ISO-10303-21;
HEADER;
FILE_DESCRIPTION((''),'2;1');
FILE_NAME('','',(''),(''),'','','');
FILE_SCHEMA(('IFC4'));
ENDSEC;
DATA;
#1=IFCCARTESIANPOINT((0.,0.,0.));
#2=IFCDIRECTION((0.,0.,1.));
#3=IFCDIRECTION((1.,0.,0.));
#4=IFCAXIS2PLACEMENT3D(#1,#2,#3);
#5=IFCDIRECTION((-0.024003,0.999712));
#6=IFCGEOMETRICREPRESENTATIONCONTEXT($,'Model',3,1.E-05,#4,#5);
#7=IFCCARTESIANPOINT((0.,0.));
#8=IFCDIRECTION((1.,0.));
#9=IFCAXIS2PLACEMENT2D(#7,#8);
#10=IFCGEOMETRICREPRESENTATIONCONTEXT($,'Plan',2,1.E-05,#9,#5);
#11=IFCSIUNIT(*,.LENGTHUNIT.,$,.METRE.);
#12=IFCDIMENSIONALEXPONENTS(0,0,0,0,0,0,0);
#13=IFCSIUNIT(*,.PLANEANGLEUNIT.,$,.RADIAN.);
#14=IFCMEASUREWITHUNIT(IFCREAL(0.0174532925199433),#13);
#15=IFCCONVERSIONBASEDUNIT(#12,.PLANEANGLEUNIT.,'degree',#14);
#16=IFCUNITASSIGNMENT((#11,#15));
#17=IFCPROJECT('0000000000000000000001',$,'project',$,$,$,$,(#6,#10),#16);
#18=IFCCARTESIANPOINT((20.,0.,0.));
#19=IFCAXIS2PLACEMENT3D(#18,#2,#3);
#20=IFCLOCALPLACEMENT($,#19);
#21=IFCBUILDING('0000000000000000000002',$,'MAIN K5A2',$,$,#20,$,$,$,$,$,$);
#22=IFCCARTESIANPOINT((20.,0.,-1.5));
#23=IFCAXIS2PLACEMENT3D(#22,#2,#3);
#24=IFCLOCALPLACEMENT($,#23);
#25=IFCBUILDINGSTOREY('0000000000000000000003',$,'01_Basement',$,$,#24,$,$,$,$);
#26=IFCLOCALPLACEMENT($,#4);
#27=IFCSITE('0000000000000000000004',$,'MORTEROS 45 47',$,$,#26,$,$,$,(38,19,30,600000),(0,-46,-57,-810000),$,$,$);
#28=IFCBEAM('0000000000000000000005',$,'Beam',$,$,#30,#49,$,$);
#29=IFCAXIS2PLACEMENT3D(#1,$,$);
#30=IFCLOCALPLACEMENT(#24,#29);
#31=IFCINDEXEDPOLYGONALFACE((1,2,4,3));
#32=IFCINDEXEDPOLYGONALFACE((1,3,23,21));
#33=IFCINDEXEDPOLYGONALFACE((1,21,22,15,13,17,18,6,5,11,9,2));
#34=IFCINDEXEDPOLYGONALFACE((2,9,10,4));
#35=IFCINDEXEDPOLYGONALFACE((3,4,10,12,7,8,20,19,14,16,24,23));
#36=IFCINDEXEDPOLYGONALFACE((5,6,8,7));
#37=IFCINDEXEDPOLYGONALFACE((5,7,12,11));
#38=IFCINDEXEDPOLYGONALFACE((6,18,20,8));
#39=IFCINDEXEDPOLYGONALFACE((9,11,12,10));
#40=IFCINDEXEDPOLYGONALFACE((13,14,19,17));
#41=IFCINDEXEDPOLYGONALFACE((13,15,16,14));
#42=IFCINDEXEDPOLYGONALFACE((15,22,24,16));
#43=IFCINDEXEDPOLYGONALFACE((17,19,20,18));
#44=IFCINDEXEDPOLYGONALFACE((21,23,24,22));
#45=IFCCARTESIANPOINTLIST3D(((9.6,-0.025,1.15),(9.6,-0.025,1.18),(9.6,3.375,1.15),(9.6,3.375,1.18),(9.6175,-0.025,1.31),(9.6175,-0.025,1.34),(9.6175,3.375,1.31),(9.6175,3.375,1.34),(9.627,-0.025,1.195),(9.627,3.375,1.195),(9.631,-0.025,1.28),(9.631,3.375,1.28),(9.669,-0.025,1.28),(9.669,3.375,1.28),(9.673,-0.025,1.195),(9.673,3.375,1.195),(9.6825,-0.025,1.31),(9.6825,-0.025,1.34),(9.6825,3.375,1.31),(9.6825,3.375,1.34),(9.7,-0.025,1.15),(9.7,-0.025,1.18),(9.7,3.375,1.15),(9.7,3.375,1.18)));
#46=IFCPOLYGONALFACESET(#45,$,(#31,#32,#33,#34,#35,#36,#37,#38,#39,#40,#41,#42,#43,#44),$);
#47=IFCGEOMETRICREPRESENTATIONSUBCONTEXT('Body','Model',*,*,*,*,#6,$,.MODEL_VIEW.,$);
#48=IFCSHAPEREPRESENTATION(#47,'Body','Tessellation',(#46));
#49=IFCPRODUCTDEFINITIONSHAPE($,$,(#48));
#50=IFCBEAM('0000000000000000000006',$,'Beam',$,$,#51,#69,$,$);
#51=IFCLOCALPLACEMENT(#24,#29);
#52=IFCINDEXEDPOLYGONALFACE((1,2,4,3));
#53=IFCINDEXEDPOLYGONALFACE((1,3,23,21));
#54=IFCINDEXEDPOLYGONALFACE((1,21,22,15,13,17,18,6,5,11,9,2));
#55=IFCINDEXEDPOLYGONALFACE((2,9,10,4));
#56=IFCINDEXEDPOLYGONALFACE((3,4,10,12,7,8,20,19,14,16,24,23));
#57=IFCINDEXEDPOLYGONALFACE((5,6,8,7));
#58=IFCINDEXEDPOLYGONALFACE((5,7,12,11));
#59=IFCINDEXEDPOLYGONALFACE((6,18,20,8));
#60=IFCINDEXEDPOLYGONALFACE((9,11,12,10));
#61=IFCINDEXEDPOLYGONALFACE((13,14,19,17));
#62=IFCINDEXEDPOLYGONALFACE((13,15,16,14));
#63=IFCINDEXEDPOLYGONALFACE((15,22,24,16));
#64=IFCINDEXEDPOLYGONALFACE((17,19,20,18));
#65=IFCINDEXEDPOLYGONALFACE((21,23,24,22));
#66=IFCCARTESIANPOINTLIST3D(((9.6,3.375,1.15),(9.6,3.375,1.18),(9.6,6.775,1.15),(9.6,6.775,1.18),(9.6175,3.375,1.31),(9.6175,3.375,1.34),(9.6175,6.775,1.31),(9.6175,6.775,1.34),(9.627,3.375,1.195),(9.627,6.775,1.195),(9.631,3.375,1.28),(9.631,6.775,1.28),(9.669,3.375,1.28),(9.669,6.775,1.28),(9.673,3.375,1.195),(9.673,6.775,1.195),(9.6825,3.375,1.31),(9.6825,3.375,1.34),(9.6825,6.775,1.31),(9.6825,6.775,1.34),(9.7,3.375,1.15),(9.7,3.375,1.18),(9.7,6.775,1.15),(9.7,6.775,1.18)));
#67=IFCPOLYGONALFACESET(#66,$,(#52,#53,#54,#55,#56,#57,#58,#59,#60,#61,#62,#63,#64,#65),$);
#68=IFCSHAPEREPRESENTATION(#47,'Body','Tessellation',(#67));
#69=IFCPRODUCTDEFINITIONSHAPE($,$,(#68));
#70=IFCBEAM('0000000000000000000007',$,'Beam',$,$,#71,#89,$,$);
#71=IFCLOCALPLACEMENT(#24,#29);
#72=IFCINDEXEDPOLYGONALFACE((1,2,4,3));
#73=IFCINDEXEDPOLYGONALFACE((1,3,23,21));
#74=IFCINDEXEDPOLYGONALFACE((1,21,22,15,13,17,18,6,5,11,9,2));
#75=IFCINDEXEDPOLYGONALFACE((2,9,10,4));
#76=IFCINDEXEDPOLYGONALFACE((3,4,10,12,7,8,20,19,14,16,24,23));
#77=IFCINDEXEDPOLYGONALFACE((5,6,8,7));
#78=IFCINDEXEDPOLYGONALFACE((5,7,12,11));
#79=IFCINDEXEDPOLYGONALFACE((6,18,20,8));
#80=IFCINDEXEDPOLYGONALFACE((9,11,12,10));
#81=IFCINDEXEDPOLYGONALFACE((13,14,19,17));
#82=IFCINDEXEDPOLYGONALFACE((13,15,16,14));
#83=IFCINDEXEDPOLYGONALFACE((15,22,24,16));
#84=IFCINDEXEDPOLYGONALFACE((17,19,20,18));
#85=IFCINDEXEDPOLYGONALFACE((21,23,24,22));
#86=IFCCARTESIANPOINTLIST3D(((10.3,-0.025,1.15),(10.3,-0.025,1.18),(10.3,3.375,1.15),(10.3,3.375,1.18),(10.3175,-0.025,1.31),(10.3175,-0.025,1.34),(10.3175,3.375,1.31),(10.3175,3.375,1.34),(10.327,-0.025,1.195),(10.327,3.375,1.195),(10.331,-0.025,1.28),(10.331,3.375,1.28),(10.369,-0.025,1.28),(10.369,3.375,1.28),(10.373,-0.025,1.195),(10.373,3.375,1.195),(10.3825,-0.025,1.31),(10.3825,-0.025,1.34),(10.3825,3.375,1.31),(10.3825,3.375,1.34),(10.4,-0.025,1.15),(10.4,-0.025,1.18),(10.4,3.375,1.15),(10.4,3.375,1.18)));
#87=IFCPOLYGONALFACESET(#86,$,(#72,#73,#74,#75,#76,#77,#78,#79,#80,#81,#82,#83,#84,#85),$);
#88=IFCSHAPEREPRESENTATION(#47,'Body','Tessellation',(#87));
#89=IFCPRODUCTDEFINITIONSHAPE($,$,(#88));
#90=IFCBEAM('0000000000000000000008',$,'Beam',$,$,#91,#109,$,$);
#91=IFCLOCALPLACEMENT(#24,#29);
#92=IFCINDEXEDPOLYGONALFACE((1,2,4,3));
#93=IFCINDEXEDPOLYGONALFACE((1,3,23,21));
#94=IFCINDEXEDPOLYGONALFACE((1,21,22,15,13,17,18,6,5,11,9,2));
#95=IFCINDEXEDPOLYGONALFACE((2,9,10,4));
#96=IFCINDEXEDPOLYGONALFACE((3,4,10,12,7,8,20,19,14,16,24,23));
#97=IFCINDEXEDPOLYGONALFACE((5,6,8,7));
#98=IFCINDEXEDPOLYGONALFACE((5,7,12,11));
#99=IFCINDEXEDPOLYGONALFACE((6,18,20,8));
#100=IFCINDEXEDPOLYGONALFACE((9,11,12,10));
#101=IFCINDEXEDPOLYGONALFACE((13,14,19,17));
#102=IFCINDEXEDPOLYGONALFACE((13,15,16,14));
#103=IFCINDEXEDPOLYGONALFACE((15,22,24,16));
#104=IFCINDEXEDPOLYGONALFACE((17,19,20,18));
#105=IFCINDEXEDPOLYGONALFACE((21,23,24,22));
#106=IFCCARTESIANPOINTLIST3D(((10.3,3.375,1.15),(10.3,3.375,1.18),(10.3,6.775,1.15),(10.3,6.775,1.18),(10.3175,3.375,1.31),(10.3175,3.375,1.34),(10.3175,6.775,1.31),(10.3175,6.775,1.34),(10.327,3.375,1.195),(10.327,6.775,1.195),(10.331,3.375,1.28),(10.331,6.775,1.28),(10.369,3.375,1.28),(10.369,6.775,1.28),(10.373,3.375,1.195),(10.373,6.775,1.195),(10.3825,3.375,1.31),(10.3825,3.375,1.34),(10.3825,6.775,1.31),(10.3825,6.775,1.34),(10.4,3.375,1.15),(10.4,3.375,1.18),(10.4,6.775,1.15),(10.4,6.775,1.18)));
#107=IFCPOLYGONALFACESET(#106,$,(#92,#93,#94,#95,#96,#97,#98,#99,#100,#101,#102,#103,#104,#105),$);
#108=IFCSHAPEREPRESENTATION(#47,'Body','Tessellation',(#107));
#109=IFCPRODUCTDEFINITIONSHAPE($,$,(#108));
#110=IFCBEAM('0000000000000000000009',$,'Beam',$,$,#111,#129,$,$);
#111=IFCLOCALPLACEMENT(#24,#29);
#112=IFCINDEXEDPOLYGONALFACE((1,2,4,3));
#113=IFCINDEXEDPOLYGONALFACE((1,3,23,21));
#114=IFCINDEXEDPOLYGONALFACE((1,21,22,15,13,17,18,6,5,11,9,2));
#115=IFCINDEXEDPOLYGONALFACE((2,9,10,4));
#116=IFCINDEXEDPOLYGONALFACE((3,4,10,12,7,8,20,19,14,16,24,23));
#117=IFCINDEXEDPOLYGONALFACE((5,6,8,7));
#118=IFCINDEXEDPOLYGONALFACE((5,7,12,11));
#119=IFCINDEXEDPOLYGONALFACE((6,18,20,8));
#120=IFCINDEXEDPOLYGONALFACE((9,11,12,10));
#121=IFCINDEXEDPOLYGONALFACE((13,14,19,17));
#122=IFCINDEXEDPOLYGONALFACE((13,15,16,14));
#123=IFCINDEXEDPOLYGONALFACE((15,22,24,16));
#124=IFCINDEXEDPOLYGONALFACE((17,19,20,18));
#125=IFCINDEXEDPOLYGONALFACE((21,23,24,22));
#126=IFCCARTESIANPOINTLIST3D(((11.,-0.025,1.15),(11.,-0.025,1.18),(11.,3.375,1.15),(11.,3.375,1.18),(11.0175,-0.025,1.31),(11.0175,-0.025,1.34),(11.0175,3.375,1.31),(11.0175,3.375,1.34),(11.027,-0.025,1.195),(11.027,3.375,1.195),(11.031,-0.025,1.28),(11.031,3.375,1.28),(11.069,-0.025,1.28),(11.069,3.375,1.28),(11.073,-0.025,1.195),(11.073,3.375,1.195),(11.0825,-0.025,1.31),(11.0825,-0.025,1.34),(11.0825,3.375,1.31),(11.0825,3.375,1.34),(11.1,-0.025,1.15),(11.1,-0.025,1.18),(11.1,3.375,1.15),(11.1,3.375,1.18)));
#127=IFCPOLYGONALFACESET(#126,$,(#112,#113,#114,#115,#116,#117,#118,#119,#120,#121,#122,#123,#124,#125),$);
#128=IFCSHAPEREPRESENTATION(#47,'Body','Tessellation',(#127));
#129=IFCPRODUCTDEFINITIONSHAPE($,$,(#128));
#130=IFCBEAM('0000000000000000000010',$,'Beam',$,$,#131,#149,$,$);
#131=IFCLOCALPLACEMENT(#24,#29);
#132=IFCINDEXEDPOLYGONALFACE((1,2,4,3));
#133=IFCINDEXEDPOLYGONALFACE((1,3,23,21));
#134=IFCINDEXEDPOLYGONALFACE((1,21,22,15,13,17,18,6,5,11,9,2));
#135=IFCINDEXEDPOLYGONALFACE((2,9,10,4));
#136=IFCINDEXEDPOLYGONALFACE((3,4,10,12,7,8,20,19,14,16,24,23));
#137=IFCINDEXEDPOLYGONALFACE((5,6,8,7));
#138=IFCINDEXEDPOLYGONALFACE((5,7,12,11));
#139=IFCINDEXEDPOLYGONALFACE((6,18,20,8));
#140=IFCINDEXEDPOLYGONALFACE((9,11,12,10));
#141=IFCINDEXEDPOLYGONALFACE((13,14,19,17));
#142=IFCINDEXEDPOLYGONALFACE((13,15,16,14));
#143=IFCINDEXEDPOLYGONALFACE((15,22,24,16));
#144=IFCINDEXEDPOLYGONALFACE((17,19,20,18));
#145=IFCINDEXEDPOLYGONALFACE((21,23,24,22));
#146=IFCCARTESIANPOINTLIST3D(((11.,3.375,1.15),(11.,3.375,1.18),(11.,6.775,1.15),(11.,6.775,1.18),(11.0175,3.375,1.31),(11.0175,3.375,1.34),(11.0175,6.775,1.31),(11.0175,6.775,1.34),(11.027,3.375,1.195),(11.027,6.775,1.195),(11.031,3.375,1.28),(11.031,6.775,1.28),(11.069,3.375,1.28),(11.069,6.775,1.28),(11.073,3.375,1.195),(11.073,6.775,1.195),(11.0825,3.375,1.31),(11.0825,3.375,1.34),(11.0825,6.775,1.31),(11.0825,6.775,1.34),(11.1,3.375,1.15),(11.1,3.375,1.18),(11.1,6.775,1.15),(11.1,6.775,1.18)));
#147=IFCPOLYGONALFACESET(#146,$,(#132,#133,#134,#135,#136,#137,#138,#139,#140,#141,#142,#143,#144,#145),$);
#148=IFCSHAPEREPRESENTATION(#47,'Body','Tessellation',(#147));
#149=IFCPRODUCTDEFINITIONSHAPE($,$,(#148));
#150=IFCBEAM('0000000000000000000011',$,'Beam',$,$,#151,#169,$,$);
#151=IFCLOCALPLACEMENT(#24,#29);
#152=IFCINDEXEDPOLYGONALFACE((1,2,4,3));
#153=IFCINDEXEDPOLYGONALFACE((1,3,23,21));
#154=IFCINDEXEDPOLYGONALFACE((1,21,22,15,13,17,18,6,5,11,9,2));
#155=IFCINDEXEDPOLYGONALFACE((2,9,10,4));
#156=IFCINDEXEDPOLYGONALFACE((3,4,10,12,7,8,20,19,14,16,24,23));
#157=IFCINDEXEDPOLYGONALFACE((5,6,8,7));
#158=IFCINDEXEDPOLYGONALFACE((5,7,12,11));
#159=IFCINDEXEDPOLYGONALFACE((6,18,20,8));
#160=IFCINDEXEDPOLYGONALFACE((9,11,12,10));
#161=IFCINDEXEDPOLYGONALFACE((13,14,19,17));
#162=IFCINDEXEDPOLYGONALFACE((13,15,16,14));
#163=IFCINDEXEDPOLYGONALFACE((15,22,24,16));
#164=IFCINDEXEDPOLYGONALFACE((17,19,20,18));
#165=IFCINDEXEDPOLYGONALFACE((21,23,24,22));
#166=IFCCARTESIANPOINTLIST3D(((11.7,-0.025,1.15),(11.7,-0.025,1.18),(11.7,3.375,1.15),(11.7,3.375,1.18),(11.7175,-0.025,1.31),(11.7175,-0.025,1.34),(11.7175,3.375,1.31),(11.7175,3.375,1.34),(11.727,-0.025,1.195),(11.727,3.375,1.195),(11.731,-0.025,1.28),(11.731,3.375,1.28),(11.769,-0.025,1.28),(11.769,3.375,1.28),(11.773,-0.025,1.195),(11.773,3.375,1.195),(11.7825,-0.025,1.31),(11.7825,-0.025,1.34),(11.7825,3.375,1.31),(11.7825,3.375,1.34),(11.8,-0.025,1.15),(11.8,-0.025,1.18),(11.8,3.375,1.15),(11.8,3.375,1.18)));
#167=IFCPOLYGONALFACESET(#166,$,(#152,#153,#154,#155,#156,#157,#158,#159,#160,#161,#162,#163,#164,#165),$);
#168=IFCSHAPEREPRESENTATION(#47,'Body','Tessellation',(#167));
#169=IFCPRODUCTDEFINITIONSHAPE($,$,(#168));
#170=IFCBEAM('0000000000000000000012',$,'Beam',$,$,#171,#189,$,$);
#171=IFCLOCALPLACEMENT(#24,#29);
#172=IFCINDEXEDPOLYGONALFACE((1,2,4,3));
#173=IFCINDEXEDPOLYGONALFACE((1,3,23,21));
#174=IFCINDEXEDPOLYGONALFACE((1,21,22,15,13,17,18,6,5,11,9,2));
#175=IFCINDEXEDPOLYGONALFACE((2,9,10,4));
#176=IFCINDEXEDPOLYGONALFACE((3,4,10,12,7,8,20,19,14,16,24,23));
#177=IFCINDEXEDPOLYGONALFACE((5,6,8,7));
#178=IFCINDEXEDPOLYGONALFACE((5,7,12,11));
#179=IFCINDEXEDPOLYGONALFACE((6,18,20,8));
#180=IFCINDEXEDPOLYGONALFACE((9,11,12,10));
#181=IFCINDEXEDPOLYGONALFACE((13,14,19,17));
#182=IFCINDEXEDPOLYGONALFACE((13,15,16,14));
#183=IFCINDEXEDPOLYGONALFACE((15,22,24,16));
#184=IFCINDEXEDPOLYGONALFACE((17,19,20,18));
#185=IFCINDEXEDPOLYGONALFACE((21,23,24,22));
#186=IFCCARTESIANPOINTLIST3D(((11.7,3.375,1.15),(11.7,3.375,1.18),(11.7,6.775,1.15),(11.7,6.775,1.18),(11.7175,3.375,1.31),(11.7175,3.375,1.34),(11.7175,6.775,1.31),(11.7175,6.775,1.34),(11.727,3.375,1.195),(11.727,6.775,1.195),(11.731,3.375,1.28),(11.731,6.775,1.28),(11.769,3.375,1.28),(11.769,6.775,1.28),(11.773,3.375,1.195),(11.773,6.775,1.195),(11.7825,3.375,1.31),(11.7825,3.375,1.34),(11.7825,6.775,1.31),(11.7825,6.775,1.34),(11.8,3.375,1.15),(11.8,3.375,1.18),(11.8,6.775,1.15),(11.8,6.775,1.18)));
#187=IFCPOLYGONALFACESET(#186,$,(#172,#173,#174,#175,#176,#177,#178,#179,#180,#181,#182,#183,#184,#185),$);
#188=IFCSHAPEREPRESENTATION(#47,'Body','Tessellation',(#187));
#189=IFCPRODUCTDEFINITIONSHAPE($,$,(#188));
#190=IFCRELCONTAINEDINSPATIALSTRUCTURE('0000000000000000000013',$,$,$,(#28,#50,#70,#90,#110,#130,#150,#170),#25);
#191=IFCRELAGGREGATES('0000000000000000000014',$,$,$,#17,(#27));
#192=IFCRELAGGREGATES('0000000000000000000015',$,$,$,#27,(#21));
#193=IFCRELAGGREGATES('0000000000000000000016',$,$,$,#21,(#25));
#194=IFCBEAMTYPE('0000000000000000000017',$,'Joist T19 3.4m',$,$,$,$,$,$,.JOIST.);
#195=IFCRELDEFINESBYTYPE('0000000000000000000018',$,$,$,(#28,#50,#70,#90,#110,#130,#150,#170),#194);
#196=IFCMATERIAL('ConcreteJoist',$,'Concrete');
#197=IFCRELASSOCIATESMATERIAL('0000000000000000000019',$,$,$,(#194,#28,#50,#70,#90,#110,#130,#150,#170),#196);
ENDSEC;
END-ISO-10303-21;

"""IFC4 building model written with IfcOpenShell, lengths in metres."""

from ifc_helpers import new_model, entity, si_unit, converted_unit, direction, frame, origin_with_axes, origin_2d_with_axis, place, context, subcontext, project, spatial, indexed_curve, outline, extrude, material, material_profile, profile_set, profile_usage, type_object, element, save


model = new_model("IFC4")

# Units and contexts
model_context = context("Model", 3, precision=1e-05, world=origin_with_axes(), true_north=direction((-0.024003, 0.999712)))
plan_context = context("Plan", 2, precision=1e-05, world=origin_2d_with_axis(), true_north=direction((-0.024003, 0.999712)))
body_context = subcontext(model_context, "Body", "Model", "MODEL_VIEW")
ifc_project = project(units=[si_unit("LENGTHUNIT", "METRE"), converted_unit("PLANEANGLEUNIT", "degree", entity("IfcReal", 0.0174532925199433), si_unit("PLANEANGLEUNIT", "RADIAN"), dimensions=[0, 0, 0, 0, 0, 0, 0])], contexts=[model_context, plan_context])

# Site, building, storey
site_placement = place(None, origin_with_axes())
site = spatial("IfcSite", under=ifc_project, at=site_placement, Name="MORTEROS 45 47", RefLatitude=(38, 19, 30, 600000), RefLongitude=(0, -46, -57, -810000))
building_placement = place(None, frame((20.0, 0.0, 0.0), z_axis=(0.0, 0.0, 1.0), x_axis=(1.0, 0.0, 0.0)))
building = spatial("IfcBuilding", under=site, at=building_placement, Name="MAIN K5A2")
storey_placement = place(None, frame((20.0, 0.0, -1.5), z_axis=(0.0, 0.0, 1.0), x_axis=(1.0, 0.0, 0.0)))
storey = spatial("IfcBuildingStorey", under=building, at=storey_placement, Name="01_Basement")

# Beams
ifc_material = material(Name="ConcreteJoist", Category="Concrete")
ifc_material_profile = material_profile(ifc_material, outline(indexed_curve([(0.019, 0.13), (0.023, 0.045), (0.05, 0.03), (0.05, 0.0), (-0.05, 0.0), (-0.05, 0.03), (-0.023, 0.045), (-0.019, 0.13), (-0.0325, 0.16), (-0.0325, 0.19), (0.0325, 0.19), (0.0325, 0.16), (0.019, 0.13)])))
ifc_profile_set = profile_set([ifc_material_profile], Name="JoistMaterialProfileSet")
beam_type = type_object("IfcBeamType", Name="Joist T19 3.4m", PredefinedType="JOIST", material=ifc_profile_set)
ifc_profile_usage_1 = profile_usage(ifc_profile_set, cardinal=5)
beam_1_placement = place(None, frame((29.65, -0.025, -0.35), z_axis=(0.0, 1.0, 0.0), x_axis=(-1.0, 0.0, 0.0)))
element("IfcBeam", 1, at=beam_1_placement, inside=storey, type_object=beam_type, material=ifc_profile_usage_1, Name="Beam", context=body_context, shape_type="SweptSolid", body=[
    extrude(outline(indexed_curve([(0.019, 0.13), (0.023, 0.045), (0.05, 0.03), (0.05, 0.0), (-0.05, 0.0), (-0.05, 0.03), (-0.023, 0.045), (-0.019, 0.13), (-0.0325, 0.16), (-0.0325, 0.19), (0.0325, 0.19), (0.0325, 0.16), (0.019, 0.13)])), origin_with_axes(), (0.0, 0.0, 1.0), 3.4),
])
ifc_profile_usage_2 = profile_usage(ifc_profile_set, cardinal=5)
beam_2_placement = place(None, frame((29.65, 3.375, -0.35), z_axis=(0.0, 1.0, 0.0), x_axis=(-1.0, 0.0, 0.0)))
element("IfcBeam", 2, at=beam_2_placement, inside=storey, type_object=beam_type, material=ifc_profile_usage_2, Name="Beam", context=body_context, shape_type="SweptSolid", body=[
    extrude(outline(indexed_curve([(0.019, 0.13), (0.023, 0.045), (0.05, 0.03), (0.05, 0.0), (-0.05, 0.0), (-0.05, 0.03), (-0.023, 0.045), (-0.019, 0.13), (-0.0325, 0.16), (-0.0325, 0.19), (0.0325, 0.19), (0.0325, 0.16), (0.019, 0.13)])), origin_with_axes(), (0.0, 0.0, 1.0), 3.4),
])
ifc_profile_usage_3 = profile_usage(ifc_profile_set, cardinal=5)
beam_3_placement = place(None, frame((30.35, -0.025, -0.35), z_axis=(0.0, 1.0, 0.0), x_axis=(-1.0, 0.0, 0.0)))
element("IfcBeam", 3, at=beam_3_placement, inside=storey, type_object=beam_type, material=ifc_profile_usage_3, Name="Beam", context=body_context, shape_type="SweptSolid", body=[
    extrude(outline(indexed_curve([(0.019, 0.13), (0.023, 0.045), (0.05, 0.03), (0.05, 0.0), (-0.05, 0.0), (-0.05, 0.03), (-0.023, 0.045), (-0.019, 0.13), (-0.0325, 0.16), (-0.0325, 0.19), (0.0325, 0.19), (0.0325, 0.16), (0.019, 0.13)])), origin_with_axes(), (0.0, 0.0, 1.0), 3.4),
])
ifc_profile_usage_4 = profile_usage(ifc_profile_set, cardinal=5)
beam_4_placement = place(None, frame((30.35, 3.375, -0.35), z_axis=(0.0, 1.0, 0.0), x_axis=(-1.0, 0.0, 0.0)))
element("IfcBeam", 4, at=beam_4_placement, inside=storey, type_object=beam_type, material=ifc_profile_usage_4, Name="Beam", context=body_context, shape_type="SweptSolid", body=[
    extrude(outline(indexed_curve([(0.019, 0.13), (0.023, 0.045), (0.05, 0.03), (0.05, 0.0), (-0.05, 0.0), (-0.05, 0.03), (-0.023, 0.045), (-0.019, 0.13), (-0.0325, 0.16), (-0.0325, 0.19), (0.0325, 0.19), (0.0325, 0.16), (0.019, 0.13)])), origin_with_axes(), (0.0, 0.0, 1.0), 3.4),
])
ifc_profile_usage_5 = profile_usage(ifc_profile_set, cardinal=5)
beam_5_placement = place(None, frame((31.05, -0.025, -0.35), z_axis=(0.0, 1.0, 0.0), x_axis=(-1.0, 0.0, 0.0)))
element("IfcBeam", 5, at=beam_5_placement, inside=storey, type_object=beam_type, material=ifc_profile_usage_5, Name="Beam", context=body_context, shape_type="SweptSolid", body=[
    extrude(outline(indexed_curve([(0.019, 0.13), (0.023, 0.045), (0.05, 0.03), (0.05, 0.0), (-0.05, 0.0), (-0.05, 0.03), (-0.023, 0.045), (-0.019, 0.13), (-0.0325, 0.16), (-0.0325, 0.19), (0.0325, 0.19), (0.0325, 0.16), (0.019, 0.13)])), origin_with_axes(), (0.0, 0.0, 1.0), 3.4),
])
ifc_profile_usage_6 = profile_usage(ifc_profile_set, cardinal=5)
beam_6_placement = place(None, frame((31.05, 3.375, -0.35), z_axis=(0.0, 1.0, 0.0), x_axis=(-1.0, 0.0, 0.0)))
element("IfcBeam", 6, at=beam_6_placement, inside=storey, type_object=beam_type, material=ifc_profile_usage_6, Name="Beam", context=body_context, shape_type="SweptSolid", body=[
    extrude(outline(indexed_curve([(0.019, 0.13), (0.023, 0.045), (0.05, 0.03), (0.05, 0.0), (-0.05, 0.0), (-0.05, 0.03), (-0.023, 0.045), (-0.019, 0.13), (-0.0325, 0.16), (-0.0325, 0.19), (0.0325, 0.19), (0.0325, 0.16), (0.019, 0.13)])), origin_with_axes(), (0.0, 0.0, 1.0), 3.4),
])
ifc_profile_usage_7 = profile_usage(ifc_profile_set, cardinal=5)
beam_7_placement = place(None, frame((31.75, -0.025, -0.35), z_axis=(0.0, 1.0, 0.0), x_axis=(-1.0, 0.0, 0.0)))
element("IfcBeam", 7, at=beam_7_placement, inside=storey, type_object=beam_type, material=ifc_profile_usage_7, Name="Beam", context=body_context, shape_type="SweptSolid", body=[
    extrude(outline(indexed_curve([(0.019, 0.13), (0.023, 0.045), (0.05, 0.03), (0.05, 0.0), (-0.05, 0.0), (-0.05, 0.03), (-0.023, 0.045), (-0.019, 0.13), (-0.0325, 0.16), (-0.0325, 0.19), (0.0325, 0.19), (0.0325, 0.16), (0.019, 0.13)])), origin_with_axes(), (0.0, 0.0, 1.0), 3.4),
])
ifc_profile_usage_8 = profile_usage(ifc_profile_set, cardinal=5)
beam_8_placement = place(None, frame((31.75, 3.375, -0.35), z_axis=(0.0, 1.0, 0.0), x_axis=(-1.0, 0.0, 0.0)))
element("IfcBeam", 8, at=beam_8_placement, inside=storey, type_object=beam_type, material=ifc_profile_usage_8, Name="Beam", context=body_context, shape_type="SweptSolid", body=[
    extrude(outline(indexed_curve([(0.019, 0.13), (0.023, 0.045), (0.05, 0.03), (0.05, 0.0), (-0.05, 0.0), (-0.05, 0.03), (-0.023, 0.045), (-0.019, 0.13), (-0.0325, 0.16), (-0.0325, 0.19), (0.0325, 0.19), (0.0325, 0.16), (0.019, 0.13)])), origin_with_axes(), (0.0, 0.0, 1.0), 3.4),
])

save(model, "model.ifc")
